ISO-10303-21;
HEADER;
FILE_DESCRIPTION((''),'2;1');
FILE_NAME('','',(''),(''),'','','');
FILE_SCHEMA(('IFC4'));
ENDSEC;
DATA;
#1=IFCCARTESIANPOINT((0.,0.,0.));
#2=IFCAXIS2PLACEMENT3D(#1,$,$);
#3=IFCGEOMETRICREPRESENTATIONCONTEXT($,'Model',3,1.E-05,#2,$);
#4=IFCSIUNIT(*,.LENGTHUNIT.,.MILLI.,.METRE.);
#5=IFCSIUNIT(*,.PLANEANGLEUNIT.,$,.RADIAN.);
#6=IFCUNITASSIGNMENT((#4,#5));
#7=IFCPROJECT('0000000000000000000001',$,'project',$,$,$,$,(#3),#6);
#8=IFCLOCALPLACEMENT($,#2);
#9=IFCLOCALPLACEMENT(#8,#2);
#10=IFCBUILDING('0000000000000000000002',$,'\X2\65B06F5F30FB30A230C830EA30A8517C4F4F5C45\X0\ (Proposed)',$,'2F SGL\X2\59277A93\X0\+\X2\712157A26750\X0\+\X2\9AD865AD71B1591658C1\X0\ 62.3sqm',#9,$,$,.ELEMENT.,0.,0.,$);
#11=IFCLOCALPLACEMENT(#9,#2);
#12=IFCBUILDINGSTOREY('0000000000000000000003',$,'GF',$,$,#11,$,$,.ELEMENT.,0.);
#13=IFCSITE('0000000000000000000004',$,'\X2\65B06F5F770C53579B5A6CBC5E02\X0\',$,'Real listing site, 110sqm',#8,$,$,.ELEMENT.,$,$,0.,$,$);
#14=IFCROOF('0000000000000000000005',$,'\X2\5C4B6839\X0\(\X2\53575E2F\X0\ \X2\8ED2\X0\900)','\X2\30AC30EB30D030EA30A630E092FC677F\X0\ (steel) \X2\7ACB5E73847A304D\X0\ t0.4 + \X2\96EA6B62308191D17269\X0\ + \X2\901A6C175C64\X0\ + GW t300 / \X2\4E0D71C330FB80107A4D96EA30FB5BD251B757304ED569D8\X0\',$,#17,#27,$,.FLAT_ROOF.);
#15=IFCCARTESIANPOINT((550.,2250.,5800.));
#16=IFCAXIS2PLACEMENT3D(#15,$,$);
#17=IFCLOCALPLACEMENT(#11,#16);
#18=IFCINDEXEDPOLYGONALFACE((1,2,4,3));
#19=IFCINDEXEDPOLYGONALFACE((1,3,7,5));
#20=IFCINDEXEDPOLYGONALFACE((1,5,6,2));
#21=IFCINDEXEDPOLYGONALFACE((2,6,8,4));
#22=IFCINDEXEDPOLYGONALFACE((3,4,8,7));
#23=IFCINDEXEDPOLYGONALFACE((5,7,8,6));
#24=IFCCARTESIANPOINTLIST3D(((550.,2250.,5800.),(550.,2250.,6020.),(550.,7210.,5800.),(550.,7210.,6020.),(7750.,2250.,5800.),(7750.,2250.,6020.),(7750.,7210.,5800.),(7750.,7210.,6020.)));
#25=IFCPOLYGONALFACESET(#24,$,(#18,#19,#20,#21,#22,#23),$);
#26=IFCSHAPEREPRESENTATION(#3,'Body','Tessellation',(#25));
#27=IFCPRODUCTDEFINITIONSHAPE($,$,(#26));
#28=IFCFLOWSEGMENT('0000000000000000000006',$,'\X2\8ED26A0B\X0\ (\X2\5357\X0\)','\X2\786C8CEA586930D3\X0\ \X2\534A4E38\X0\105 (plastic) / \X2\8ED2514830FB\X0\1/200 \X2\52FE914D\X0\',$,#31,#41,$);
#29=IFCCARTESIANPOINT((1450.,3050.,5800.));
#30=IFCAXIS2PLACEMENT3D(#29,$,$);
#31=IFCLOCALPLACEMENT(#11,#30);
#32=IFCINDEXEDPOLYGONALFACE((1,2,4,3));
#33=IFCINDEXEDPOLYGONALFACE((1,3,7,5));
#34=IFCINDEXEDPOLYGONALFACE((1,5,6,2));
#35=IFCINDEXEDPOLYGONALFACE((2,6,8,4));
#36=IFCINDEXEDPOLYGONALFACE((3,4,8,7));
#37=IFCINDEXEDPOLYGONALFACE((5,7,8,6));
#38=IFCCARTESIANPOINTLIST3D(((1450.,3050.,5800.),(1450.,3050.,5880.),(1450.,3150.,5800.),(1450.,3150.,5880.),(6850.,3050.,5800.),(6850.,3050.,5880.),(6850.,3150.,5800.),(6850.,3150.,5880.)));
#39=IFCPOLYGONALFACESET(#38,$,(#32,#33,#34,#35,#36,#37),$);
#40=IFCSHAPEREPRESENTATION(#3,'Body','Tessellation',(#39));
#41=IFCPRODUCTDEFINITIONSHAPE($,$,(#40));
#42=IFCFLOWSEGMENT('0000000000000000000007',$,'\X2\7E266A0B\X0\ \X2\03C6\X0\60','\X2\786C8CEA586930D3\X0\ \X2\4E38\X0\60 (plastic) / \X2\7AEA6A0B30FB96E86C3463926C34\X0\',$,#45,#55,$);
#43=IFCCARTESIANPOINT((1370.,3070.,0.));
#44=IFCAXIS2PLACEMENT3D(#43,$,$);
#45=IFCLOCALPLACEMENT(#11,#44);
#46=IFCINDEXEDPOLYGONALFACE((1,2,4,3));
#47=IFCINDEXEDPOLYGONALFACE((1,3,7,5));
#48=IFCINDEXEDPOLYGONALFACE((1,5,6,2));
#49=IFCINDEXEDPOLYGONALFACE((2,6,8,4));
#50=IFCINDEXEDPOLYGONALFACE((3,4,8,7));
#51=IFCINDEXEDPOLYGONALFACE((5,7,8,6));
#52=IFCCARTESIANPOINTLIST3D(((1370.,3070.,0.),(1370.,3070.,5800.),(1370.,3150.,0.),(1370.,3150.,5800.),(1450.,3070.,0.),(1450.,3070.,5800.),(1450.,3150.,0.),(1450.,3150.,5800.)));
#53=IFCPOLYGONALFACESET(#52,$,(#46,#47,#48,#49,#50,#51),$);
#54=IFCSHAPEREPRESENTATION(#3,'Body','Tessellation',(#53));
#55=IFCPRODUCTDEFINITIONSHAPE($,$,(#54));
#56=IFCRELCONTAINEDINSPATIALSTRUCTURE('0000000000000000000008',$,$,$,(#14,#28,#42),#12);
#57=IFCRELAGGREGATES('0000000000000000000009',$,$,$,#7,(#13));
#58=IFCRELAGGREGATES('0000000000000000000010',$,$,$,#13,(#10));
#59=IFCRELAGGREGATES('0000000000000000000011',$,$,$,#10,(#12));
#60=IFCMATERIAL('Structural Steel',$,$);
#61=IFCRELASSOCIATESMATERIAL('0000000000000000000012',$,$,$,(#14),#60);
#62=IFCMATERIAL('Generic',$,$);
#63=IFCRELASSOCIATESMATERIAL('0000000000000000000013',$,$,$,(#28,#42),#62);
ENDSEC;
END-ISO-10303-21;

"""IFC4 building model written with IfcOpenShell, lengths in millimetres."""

from ifc_helpers import new_model, si_unit, frame, frame_2d, origin, place, context, project, spatial, rectangle, extrude, material, element, save


model = new_model("IFC4")

# Units and contexts
model_context = context("Model", 3, precision=1e-05, world=origin())
ifc_project = project(units=[si_unit("LENGTHUNIT", "METRE", prefix="MILLI"), si_unit("PLANEANGLEUNIT", "RADIAN")], contexts=[model_context])

# Site, building, storey
site_placement = place(None, origin())
site = spatial("IfcSite", under=ifc_project, at=site_placement, Name="新潟県南魚沼市", ObjectType="Real listing site, 110sqm", CompositionType="ELEMENT", RefElevation=0.0)
building_placement = place(site_placement, origin())
building = spatial("IfcBuilding", under=site, at=building_placement, Name="新潟・アトリエ兼住居 (Proposed)", ObjectType="2F SGL大窓+無垢材+高断熱外壁 62.3sqm", CompositionType="ELEMENT", ElevationOfRefHeight=0.0, ElevationOfTerrain=0.0)
storey_placement = place(building_placement, origin())
storey = spatial("IfcBuildingStorey", under=building, at=storey_placement, Name="GF", CompositionType="ELEMENT", Elevation=0.0)

# Roof
ifc_material_1 = material(Name="Structural Steel")
for number, where, name in (
    (1, (550.0, 2250.0, 5800.0), "屋根(南帯 軒900)"),
):
    element("IfcRoof", number, at=place(storey_placement, frame(where)), inside=storey, material=ifc_material_1, Name=name, Description="ガルバリウム鋼板 (steel) 立平葺き t0.4 + 雪止め金物 + 通気層 + GW t300 / 不燃・耐積雪・寒冷地仕様", PredefinedType="FLAT_ROOF", context=model_context, shape_type="SweptSolid", body=[
        extrude(rectangle(XDim=7200.0, YDim=4960.0, at=frame_2d((3600.0, 2480.0))), frame((550.0, 2250.0, 5800.0)), (0.0, 0.0, 1.0), 220.0),
    ])

# Flow segments
ifc_material_2 = material(Name="Generic")
flow_segment_1_placement = place(storey_placement, frame((1450.0, 3050.0, 5800.0)))
element("IfcFlowSegment", 2, at=flow_segment_1_placement, inside=storey, material=ifc_material_2, Name="軒樋 (南)", Description="硬質塩ビ 半丸105 (plastic) / 軒先・1/200 勾配", context=model_context, shape_type="SweptSolid", body=[
    extrude(rectangle(XDim=5400.0, YDim=100.0, at=frame_2d((2700.0, 50.0))), frame((1450.0, 3050.0, 5800.0)), (0.0, 0.0, 1.0), 80.0),
])
flow_segment_2_placement = place(storey_placement, frame((1370.0, 3070.0, 0.0)))
element("IfcFlowSegment", 3, at=flow_segment_2_placement, inside=storey, material=ifc_material_2, Name="縦樋 φ60", Description="硬質塩ビ 丸60 (plastic) / 竪樋・雨水排水", context=model_context, shape_type="SweptSolid", body=[
    extrude(rectangle(XDim=80.0, YDim=80.0, at=frame_2d((40.0, 40.0))), frame((1370.0, 3070.0, 0.0)), (0.0, 0.0, 1.0), 5800.0),
])

save(model, "model.ifc")
